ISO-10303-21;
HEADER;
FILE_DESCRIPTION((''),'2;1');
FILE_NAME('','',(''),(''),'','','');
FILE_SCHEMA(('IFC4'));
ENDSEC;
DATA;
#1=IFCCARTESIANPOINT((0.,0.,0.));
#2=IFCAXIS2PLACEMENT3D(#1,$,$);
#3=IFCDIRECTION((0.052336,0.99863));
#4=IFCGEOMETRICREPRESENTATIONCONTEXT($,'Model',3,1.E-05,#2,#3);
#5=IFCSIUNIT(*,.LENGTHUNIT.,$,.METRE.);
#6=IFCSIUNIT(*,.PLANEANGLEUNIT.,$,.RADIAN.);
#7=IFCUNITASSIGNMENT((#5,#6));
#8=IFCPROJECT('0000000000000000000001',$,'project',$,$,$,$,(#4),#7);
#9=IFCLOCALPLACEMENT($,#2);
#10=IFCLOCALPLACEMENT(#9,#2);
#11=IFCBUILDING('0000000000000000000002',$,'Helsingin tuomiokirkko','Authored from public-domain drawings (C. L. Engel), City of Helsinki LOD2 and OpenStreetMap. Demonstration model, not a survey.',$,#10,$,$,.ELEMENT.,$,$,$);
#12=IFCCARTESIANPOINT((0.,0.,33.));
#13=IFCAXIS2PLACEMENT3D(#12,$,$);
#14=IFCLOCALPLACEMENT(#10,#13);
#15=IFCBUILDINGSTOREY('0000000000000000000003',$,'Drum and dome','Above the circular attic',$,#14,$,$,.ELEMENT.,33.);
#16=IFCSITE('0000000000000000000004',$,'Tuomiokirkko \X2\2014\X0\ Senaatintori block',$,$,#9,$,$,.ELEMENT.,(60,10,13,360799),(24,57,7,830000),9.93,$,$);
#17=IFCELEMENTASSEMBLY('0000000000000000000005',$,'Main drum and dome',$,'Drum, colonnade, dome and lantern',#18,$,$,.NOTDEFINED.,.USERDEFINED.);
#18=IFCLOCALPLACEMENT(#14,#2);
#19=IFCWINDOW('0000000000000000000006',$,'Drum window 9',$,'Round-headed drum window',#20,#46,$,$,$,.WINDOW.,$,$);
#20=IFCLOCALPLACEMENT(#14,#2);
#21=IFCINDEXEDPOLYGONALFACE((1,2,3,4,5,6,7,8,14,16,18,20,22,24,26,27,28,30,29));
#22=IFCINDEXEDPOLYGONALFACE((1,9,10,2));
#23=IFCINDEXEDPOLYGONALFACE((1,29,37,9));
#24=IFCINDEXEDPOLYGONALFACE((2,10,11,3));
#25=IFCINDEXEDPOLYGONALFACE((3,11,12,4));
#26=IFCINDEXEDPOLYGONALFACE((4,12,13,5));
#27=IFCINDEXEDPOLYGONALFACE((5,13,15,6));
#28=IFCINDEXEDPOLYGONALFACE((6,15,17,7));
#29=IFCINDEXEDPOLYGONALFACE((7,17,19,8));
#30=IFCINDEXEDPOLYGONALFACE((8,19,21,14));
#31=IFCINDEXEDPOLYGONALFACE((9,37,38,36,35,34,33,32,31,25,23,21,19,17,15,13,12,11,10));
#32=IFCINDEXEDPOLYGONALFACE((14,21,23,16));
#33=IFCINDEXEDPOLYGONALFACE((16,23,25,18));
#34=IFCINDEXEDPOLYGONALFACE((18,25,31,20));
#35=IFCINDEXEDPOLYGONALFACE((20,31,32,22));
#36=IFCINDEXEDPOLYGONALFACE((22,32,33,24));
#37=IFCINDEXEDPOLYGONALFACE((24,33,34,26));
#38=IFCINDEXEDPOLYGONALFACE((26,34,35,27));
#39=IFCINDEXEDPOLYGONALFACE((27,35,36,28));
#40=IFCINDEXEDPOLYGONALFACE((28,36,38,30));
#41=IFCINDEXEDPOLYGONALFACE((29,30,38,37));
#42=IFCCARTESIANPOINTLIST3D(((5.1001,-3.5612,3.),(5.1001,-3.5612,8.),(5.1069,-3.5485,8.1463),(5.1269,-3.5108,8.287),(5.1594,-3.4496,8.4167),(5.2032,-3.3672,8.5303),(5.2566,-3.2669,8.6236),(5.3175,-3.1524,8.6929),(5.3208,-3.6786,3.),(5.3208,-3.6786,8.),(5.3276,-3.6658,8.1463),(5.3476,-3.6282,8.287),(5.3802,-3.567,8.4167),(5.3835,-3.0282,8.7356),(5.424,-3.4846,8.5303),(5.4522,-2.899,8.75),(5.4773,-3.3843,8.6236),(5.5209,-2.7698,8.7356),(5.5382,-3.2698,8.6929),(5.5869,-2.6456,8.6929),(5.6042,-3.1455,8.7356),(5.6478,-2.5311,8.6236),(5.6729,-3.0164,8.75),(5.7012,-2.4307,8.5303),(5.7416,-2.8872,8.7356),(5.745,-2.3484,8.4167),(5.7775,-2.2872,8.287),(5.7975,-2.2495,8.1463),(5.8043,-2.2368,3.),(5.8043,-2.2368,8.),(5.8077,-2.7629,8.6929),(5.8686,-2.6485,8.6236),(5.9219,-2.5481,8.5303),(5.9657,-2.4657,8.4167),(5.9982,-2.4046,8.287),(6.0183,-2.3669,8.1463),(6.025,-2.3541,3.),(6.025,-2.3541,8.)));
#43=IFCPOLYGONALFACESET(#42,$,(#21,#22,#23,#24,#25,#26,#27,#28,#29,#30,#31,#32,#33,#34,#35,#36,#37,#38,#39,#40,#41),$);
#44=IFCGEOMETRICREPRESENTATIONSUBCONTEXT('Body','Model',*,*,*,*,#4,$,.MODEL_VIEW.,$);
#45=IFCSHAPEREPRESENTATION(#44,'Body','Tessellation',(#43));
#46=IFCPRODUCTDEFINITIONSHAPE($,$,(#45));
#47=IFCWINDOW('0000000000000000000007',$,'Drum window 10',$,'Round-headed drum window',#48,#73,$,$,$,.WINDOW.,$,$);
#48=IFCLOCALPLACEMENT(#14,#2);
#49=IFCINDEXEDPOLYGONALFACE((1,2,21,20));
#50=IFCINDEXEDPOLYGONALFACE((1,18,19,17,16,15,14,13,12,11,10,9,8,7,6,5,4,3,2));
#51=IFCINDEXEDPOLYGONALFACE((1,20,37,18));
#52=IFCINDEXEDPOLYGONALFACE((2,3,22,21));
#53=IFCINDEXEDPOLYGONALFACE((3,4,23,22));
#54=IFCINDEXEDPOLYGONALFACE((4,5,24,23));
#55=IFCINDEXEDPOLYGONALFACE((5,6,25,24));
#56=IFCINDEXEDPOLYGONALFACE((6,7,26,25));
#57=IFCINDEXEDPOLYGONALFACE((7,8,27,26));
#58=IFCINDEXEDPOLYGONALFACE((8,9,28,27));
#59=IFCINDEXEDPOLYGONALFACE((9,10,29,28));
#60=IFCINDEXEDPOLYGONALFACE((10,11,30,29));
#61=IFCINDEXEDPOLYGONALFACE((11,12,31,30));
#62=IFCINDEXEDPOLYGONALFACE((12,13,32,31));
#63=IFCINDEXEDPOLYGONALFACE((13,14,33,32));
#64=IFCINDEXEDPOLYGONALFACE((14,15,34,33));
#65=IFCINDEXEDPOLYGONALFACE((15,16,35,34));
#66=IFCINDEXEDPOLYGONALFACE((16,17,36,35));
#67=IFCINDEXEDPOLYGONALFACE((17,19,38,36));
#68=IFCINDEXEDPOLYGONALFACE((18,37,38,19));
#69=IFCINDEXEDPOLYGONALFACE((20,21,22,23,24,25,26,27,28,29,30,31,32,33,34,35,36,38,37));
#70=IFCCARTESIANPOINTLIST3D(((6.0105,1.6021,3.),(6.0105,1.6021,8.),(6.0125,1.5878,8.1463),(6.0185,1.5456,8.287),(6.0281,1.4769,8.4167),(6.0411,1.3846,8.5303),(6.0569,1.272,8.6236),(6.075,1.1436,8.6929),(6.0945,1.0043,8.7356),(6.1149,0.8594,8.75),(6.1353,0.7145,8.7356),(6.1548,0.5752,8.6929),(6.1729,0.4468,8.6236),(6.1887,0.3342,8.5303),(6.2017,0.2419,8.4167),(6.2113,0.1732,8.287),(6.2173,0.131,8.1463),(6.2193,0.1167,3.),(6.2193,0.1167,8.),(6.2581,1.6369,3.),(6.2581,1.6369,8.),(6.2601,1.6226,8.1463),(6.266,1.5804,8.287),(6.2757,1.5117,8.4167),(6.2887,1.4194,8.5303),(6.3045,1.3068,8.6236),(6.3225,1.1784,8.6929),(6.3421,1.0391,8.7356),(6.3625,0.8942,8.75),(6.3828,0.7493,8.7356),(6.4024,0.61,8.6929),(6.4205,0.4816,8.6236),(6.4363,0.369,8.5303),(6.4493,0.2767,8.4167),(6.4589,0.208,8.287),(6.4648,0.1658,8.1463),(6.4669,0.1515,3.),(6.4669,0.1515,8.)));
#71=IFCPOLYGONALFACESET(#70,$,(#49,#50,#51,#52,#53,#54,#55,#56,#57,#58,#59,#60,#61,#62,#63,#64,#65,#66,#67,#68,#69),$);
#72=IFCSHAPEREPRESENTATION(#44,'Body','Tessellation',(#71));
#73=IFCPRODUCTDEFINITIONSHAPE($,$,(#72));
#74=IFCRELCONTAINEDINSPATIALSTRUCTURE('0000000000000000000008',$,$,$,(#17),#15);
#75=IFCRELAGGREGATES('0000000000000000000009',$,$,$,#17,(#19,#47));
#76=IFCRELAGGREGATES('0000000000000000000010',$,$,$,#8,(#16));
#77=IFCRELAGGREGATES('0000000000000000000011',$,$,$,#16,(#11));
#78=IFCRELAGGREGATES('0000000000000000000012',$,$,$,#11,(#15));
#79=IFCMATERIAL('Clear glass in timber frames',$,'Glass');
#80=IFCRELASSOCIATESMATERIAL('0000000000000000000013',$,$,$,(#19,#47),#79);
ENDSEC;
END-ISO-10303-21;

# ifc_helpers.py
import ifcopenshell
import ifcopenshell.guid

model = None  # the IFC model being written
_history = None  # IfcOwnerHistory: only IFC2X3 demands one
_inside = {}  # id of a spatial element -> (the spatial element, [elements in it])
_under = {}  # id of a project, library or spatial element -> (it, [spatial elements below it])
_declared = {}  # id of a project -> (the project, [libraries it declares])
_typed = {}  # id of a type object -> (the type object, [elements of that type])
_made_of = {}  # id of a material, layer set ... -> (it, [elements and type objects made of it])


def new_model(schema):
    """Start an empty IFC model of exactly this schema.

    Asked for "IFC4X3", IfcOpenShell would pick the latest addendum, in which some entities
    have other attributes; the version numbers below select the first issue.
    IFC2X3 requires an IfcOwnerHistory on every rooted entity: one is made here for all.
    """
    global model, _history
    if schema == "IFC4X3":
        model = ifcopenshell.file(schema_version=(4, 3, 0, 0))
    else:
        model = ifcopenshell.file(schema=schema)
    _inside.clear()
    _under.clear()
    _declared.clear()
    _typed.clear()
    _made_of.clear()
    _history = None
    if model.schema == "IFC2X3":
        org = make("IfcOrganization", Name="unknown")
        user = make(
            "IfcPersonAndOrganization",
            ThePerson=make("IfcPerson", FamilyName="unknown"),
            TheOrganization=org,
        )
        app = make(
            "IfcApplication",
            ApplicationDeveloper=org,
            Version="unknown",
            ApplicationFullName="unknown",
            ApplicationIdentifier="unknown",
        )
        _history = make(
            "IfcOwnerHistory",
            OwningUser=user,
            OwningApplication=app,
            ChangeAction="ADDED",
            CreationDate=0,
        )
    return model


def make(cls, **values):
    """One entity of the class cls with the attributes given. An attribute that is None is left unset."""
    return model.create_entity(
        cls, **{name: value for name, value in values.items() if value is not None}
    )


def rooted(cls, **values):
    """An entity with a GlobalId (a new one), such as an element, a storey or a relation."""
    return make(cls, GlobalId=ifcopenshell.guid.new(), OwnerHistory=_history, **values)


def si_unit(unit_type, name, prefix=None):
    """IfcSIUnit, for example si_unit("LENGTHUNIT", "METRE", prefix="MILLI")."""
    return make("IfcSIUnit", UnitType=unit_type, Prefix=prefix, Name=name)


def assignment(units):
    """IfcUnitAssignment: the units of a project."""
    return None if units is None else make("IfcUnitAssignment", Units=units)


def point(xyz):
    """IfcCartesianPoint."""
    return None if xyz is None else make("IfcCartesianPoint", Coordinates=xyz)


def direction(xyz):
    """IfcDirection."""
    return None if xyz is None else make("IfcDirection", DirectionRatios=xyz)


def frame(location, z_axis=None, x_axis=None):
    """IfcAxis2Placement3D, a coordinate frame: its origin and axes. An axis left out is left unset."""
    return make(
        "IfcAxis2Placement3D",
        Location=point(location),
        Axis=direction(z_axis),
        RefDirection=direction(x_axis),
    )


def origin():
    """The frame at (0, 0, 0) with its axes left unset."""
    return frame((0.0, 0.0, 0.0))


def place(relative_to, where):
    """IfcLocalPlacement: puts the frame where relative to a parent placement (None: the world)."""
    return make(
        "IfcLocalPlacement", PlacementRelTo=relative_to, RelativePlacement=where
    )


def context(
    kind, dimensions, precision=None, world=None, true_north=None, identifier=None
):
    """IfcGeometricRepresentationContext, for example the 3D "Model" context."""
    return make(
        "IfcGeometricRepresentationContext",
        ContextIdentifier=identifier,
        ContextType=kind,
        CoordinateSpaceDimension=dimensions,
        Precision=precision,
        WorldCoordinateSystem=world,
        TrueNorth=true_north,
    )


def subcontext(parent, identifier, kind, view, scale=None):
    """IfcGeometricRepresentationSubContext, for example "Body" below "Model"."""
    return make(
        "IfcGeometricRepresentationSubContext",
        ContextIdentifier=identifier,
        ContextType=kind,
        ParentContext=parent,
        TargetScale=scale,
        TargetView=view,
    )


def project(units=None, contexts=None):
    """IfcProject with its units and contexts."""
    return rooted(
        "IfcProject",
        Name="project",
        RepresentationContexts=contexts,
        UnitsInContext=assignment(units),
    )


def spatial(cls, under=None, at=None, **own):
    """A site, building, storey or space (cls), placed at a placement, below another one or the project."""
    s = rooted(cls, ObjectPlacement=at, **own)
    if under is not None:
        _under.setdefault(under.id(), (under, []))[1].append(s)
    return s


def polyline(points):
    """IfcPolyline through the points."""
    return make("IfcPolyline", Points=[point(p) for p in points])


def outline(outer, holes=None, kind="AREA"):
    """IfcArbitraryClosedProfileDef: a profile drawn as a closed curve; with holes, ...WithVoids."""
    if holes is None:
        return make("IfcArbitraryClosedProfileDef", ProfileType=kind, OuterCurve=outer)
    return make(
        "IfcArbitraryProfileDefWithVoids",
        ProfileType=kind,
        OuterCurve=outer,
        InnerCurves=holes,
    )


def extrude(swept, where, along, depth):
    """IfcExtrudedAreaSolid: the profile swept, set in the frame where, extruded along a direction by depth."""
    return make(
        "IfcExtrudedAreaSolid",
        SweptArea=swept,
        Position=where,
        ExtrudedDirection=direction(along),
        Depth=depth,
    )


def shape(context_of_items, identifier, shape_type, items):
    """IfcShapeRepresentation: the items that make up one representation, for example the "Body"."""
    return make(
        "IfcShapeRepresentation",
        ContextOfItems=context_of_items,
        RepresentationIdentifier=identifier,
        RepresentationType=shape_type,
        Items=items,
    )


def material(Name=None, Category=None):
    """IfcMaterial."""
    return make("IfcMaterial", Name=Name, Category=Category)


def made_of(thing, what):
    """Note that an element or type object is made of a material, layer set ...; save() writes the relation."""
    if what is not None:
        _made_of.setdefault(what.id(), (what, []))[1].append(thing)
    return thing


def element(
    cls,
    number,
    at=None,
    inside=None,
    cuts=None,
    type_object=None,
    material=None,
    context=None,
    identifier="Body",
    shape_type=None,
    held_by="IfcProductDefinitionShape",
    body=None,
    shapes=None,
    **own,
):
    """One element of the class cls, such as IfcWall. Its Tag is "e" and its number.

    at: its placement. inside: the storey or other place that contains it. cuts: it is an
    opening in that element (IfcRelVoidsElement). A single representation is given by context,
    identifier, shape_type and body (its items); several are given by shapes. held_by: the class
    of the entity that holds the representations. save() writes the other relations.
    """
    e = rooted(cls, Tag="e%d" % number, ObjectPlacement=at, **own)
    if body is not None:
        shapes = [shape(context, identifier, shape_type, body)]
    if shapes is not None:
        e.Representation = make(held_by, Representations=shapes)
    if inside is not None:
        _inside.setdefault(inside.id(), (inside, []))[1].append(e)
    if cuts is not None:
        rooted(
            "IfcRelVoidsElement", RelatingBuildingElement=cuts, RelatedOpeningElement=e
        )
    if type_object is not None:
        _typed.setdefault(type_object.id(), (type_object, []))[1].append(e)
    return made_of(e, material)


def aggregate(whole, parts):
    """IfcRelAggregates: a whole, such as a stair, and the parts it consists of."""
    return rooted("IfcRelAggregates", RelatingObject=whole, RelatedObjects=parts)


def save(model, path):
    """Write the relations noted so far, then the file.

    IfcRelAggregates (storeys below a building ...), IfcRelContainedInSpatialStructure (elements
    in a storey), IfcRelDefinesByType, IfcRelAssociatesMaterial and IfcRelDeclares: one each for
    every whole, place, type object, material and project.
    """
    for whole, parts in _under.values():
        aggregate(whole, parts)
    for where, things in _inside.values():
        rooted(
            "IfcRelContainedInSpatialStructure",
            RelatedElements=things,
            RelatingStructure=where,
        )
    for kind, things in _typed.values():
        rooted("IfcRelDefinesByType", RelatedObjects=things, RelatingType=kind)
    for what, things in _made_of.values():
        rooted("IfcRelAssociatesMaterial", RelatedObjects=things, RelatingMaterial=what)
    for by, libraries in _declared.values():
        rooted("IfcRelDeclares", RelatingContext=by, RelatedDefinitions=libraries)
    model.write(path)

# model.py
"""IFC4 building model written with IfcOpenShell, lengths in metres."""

from ifc_helpers import new_model, si_unit, direction, frame, origin, place, context, subcontext, project, spatial, polyline, outline, extrude, material, element, aggregate, save


model = new_model("IFC4")

# Units and contexts
model_context = context("Model", 3, precision=1e-05, world=origin(), true_north=direction((0.052336, 0.99863)))
body_context = subcontext(model_context, "Body", "Model", "MODEL_VIEW")
ifc_project = project(units=[si_unit("LENGTHUNIT", "METRE"), si_unit("PLANEANGLEUNIT", "RADIAN")], contexts=[model_context])

# Site, building, storey
site_placement = place(None, origin())
site = spatial("IfcSite", under=ifc_project, at=site_placement, Name="Tuomiokirkko — Senaatintori block", CompositionType="ELEMENT", RefLatitude=(60, 10, 13, 360799), RefLongitude=(24, 57, 7, 830000), RefElevation=9.93)
building_placement = place(site_placement, origin())
building = spatial("IfcBuilding", under=site, at=building_placement, Name="Helsingin tuomiokirkko", Description="Authored from public-domain drawings (C. L. Engel), City of Helsinki LOD2 and OpenStreetMap. Demonstration model, not a survey.", CompositionType="ELEMENT")
storey_placement = place(building_placement, frame((0.0, 0.0, 33.0)))
storey = spatial("IfcBuildingStorey", under=building, at=storey_placement, Name="Drum and dome", Description="Above the circular attic", CompositionType="ELEMENT", Elevation=33.0)

# Element assembly, windows
assembly_placement = place(building_placement, origin())
assembly = element("IfcElementAssembly", 1, at=assembly_placement, inside=storey, Name="Main drum and dome", ObjectType="Drum, colonnade, dome and lantern", AssemblyPlace="NOTDEFINED", PredefinedType="USERDEFINED")
ifc_material_1 = material(Name="Clear glass in timber frames", Category="Glass")
window_1_placement = place(building_placement, origin())
window_1 = element("IfcWindow", 2, at=window_1_placement, material=ifc_material_1, Name="Drum window 9", ObjectType="Round-headed drum window", PredefinedType="WINDOW", context=body_context, shape_type="SweptSolid", body=[
    extrude(outline(polyline([(-0.75, 0.0), (0.75, 0.0), (0.75, 5.0), (0.7356, 5.1463), (0.6929, 5.287), (0.6236, 5.4167), (0.5303, 5.5303), (0.4167, 5.6236), (0.287, 5.6929), (0.1463, 5.7356), (0.0, 5.75), (-0.1463, 5.7356), (-0.287, 5.6929), (-0.4167, 5.6236), (-0.5303, 5.5303), (-0.6236, 5.4167), (-0.6929, 5.287), (-0.7356, 5.1463), (-0.75, 5.0), (-0.75, 0.0)])), frame((5.4522, -2.899, 36.0), z_axis=(0.882948, -0.469472, 0.0), x_axis=(0.469472, 0.882948, 0.0)), (0.0, 0.0, 1.0), 0.25),
])
window_2_placement = place(building_placement, origin())
window_2 = element("IfcWindow", 3, at=window_2_placement, material=ifc_material_1, Name="Drum window 10", ObjectType="Round-headed drum window", PredefinedType="WINDOW", context=body_context, shape_type="SweptSolid", body=[
    extrude(outline(polyline([(-0.75, 0.0), (0.75, 0.0), (0.75, 5.0), (0.7356, 5.1463), (0.6929, 5.287), (0.6236, 5.4167), (0.5303, 5.5303), (0.4167, 5.6236), (0.287, 5.6929), (0.1463, 5.7356), (0.0, 5.75), (-0.1463, 5.7356), (-0.287, 5.6929), (-0.4167, 5.6236), (-0.5303, 5.5303), (-0.6236, 5.4167), (-0.6929, 5.287), (-0.7356, 5.1463), (-0.75, 5.0), (-0.75, 0.0)])), frame((6.1149, 0.8594, 36.0), z_axis=(0.990268, 0.139173, 0.0), x_axis=(-0.139173, 0.990268, 0.0)), (0.0, 0.0, 1.0), 0.25),
])
aggregate(assembly, [window_1, window_2])

save(model, "model.ifc")
